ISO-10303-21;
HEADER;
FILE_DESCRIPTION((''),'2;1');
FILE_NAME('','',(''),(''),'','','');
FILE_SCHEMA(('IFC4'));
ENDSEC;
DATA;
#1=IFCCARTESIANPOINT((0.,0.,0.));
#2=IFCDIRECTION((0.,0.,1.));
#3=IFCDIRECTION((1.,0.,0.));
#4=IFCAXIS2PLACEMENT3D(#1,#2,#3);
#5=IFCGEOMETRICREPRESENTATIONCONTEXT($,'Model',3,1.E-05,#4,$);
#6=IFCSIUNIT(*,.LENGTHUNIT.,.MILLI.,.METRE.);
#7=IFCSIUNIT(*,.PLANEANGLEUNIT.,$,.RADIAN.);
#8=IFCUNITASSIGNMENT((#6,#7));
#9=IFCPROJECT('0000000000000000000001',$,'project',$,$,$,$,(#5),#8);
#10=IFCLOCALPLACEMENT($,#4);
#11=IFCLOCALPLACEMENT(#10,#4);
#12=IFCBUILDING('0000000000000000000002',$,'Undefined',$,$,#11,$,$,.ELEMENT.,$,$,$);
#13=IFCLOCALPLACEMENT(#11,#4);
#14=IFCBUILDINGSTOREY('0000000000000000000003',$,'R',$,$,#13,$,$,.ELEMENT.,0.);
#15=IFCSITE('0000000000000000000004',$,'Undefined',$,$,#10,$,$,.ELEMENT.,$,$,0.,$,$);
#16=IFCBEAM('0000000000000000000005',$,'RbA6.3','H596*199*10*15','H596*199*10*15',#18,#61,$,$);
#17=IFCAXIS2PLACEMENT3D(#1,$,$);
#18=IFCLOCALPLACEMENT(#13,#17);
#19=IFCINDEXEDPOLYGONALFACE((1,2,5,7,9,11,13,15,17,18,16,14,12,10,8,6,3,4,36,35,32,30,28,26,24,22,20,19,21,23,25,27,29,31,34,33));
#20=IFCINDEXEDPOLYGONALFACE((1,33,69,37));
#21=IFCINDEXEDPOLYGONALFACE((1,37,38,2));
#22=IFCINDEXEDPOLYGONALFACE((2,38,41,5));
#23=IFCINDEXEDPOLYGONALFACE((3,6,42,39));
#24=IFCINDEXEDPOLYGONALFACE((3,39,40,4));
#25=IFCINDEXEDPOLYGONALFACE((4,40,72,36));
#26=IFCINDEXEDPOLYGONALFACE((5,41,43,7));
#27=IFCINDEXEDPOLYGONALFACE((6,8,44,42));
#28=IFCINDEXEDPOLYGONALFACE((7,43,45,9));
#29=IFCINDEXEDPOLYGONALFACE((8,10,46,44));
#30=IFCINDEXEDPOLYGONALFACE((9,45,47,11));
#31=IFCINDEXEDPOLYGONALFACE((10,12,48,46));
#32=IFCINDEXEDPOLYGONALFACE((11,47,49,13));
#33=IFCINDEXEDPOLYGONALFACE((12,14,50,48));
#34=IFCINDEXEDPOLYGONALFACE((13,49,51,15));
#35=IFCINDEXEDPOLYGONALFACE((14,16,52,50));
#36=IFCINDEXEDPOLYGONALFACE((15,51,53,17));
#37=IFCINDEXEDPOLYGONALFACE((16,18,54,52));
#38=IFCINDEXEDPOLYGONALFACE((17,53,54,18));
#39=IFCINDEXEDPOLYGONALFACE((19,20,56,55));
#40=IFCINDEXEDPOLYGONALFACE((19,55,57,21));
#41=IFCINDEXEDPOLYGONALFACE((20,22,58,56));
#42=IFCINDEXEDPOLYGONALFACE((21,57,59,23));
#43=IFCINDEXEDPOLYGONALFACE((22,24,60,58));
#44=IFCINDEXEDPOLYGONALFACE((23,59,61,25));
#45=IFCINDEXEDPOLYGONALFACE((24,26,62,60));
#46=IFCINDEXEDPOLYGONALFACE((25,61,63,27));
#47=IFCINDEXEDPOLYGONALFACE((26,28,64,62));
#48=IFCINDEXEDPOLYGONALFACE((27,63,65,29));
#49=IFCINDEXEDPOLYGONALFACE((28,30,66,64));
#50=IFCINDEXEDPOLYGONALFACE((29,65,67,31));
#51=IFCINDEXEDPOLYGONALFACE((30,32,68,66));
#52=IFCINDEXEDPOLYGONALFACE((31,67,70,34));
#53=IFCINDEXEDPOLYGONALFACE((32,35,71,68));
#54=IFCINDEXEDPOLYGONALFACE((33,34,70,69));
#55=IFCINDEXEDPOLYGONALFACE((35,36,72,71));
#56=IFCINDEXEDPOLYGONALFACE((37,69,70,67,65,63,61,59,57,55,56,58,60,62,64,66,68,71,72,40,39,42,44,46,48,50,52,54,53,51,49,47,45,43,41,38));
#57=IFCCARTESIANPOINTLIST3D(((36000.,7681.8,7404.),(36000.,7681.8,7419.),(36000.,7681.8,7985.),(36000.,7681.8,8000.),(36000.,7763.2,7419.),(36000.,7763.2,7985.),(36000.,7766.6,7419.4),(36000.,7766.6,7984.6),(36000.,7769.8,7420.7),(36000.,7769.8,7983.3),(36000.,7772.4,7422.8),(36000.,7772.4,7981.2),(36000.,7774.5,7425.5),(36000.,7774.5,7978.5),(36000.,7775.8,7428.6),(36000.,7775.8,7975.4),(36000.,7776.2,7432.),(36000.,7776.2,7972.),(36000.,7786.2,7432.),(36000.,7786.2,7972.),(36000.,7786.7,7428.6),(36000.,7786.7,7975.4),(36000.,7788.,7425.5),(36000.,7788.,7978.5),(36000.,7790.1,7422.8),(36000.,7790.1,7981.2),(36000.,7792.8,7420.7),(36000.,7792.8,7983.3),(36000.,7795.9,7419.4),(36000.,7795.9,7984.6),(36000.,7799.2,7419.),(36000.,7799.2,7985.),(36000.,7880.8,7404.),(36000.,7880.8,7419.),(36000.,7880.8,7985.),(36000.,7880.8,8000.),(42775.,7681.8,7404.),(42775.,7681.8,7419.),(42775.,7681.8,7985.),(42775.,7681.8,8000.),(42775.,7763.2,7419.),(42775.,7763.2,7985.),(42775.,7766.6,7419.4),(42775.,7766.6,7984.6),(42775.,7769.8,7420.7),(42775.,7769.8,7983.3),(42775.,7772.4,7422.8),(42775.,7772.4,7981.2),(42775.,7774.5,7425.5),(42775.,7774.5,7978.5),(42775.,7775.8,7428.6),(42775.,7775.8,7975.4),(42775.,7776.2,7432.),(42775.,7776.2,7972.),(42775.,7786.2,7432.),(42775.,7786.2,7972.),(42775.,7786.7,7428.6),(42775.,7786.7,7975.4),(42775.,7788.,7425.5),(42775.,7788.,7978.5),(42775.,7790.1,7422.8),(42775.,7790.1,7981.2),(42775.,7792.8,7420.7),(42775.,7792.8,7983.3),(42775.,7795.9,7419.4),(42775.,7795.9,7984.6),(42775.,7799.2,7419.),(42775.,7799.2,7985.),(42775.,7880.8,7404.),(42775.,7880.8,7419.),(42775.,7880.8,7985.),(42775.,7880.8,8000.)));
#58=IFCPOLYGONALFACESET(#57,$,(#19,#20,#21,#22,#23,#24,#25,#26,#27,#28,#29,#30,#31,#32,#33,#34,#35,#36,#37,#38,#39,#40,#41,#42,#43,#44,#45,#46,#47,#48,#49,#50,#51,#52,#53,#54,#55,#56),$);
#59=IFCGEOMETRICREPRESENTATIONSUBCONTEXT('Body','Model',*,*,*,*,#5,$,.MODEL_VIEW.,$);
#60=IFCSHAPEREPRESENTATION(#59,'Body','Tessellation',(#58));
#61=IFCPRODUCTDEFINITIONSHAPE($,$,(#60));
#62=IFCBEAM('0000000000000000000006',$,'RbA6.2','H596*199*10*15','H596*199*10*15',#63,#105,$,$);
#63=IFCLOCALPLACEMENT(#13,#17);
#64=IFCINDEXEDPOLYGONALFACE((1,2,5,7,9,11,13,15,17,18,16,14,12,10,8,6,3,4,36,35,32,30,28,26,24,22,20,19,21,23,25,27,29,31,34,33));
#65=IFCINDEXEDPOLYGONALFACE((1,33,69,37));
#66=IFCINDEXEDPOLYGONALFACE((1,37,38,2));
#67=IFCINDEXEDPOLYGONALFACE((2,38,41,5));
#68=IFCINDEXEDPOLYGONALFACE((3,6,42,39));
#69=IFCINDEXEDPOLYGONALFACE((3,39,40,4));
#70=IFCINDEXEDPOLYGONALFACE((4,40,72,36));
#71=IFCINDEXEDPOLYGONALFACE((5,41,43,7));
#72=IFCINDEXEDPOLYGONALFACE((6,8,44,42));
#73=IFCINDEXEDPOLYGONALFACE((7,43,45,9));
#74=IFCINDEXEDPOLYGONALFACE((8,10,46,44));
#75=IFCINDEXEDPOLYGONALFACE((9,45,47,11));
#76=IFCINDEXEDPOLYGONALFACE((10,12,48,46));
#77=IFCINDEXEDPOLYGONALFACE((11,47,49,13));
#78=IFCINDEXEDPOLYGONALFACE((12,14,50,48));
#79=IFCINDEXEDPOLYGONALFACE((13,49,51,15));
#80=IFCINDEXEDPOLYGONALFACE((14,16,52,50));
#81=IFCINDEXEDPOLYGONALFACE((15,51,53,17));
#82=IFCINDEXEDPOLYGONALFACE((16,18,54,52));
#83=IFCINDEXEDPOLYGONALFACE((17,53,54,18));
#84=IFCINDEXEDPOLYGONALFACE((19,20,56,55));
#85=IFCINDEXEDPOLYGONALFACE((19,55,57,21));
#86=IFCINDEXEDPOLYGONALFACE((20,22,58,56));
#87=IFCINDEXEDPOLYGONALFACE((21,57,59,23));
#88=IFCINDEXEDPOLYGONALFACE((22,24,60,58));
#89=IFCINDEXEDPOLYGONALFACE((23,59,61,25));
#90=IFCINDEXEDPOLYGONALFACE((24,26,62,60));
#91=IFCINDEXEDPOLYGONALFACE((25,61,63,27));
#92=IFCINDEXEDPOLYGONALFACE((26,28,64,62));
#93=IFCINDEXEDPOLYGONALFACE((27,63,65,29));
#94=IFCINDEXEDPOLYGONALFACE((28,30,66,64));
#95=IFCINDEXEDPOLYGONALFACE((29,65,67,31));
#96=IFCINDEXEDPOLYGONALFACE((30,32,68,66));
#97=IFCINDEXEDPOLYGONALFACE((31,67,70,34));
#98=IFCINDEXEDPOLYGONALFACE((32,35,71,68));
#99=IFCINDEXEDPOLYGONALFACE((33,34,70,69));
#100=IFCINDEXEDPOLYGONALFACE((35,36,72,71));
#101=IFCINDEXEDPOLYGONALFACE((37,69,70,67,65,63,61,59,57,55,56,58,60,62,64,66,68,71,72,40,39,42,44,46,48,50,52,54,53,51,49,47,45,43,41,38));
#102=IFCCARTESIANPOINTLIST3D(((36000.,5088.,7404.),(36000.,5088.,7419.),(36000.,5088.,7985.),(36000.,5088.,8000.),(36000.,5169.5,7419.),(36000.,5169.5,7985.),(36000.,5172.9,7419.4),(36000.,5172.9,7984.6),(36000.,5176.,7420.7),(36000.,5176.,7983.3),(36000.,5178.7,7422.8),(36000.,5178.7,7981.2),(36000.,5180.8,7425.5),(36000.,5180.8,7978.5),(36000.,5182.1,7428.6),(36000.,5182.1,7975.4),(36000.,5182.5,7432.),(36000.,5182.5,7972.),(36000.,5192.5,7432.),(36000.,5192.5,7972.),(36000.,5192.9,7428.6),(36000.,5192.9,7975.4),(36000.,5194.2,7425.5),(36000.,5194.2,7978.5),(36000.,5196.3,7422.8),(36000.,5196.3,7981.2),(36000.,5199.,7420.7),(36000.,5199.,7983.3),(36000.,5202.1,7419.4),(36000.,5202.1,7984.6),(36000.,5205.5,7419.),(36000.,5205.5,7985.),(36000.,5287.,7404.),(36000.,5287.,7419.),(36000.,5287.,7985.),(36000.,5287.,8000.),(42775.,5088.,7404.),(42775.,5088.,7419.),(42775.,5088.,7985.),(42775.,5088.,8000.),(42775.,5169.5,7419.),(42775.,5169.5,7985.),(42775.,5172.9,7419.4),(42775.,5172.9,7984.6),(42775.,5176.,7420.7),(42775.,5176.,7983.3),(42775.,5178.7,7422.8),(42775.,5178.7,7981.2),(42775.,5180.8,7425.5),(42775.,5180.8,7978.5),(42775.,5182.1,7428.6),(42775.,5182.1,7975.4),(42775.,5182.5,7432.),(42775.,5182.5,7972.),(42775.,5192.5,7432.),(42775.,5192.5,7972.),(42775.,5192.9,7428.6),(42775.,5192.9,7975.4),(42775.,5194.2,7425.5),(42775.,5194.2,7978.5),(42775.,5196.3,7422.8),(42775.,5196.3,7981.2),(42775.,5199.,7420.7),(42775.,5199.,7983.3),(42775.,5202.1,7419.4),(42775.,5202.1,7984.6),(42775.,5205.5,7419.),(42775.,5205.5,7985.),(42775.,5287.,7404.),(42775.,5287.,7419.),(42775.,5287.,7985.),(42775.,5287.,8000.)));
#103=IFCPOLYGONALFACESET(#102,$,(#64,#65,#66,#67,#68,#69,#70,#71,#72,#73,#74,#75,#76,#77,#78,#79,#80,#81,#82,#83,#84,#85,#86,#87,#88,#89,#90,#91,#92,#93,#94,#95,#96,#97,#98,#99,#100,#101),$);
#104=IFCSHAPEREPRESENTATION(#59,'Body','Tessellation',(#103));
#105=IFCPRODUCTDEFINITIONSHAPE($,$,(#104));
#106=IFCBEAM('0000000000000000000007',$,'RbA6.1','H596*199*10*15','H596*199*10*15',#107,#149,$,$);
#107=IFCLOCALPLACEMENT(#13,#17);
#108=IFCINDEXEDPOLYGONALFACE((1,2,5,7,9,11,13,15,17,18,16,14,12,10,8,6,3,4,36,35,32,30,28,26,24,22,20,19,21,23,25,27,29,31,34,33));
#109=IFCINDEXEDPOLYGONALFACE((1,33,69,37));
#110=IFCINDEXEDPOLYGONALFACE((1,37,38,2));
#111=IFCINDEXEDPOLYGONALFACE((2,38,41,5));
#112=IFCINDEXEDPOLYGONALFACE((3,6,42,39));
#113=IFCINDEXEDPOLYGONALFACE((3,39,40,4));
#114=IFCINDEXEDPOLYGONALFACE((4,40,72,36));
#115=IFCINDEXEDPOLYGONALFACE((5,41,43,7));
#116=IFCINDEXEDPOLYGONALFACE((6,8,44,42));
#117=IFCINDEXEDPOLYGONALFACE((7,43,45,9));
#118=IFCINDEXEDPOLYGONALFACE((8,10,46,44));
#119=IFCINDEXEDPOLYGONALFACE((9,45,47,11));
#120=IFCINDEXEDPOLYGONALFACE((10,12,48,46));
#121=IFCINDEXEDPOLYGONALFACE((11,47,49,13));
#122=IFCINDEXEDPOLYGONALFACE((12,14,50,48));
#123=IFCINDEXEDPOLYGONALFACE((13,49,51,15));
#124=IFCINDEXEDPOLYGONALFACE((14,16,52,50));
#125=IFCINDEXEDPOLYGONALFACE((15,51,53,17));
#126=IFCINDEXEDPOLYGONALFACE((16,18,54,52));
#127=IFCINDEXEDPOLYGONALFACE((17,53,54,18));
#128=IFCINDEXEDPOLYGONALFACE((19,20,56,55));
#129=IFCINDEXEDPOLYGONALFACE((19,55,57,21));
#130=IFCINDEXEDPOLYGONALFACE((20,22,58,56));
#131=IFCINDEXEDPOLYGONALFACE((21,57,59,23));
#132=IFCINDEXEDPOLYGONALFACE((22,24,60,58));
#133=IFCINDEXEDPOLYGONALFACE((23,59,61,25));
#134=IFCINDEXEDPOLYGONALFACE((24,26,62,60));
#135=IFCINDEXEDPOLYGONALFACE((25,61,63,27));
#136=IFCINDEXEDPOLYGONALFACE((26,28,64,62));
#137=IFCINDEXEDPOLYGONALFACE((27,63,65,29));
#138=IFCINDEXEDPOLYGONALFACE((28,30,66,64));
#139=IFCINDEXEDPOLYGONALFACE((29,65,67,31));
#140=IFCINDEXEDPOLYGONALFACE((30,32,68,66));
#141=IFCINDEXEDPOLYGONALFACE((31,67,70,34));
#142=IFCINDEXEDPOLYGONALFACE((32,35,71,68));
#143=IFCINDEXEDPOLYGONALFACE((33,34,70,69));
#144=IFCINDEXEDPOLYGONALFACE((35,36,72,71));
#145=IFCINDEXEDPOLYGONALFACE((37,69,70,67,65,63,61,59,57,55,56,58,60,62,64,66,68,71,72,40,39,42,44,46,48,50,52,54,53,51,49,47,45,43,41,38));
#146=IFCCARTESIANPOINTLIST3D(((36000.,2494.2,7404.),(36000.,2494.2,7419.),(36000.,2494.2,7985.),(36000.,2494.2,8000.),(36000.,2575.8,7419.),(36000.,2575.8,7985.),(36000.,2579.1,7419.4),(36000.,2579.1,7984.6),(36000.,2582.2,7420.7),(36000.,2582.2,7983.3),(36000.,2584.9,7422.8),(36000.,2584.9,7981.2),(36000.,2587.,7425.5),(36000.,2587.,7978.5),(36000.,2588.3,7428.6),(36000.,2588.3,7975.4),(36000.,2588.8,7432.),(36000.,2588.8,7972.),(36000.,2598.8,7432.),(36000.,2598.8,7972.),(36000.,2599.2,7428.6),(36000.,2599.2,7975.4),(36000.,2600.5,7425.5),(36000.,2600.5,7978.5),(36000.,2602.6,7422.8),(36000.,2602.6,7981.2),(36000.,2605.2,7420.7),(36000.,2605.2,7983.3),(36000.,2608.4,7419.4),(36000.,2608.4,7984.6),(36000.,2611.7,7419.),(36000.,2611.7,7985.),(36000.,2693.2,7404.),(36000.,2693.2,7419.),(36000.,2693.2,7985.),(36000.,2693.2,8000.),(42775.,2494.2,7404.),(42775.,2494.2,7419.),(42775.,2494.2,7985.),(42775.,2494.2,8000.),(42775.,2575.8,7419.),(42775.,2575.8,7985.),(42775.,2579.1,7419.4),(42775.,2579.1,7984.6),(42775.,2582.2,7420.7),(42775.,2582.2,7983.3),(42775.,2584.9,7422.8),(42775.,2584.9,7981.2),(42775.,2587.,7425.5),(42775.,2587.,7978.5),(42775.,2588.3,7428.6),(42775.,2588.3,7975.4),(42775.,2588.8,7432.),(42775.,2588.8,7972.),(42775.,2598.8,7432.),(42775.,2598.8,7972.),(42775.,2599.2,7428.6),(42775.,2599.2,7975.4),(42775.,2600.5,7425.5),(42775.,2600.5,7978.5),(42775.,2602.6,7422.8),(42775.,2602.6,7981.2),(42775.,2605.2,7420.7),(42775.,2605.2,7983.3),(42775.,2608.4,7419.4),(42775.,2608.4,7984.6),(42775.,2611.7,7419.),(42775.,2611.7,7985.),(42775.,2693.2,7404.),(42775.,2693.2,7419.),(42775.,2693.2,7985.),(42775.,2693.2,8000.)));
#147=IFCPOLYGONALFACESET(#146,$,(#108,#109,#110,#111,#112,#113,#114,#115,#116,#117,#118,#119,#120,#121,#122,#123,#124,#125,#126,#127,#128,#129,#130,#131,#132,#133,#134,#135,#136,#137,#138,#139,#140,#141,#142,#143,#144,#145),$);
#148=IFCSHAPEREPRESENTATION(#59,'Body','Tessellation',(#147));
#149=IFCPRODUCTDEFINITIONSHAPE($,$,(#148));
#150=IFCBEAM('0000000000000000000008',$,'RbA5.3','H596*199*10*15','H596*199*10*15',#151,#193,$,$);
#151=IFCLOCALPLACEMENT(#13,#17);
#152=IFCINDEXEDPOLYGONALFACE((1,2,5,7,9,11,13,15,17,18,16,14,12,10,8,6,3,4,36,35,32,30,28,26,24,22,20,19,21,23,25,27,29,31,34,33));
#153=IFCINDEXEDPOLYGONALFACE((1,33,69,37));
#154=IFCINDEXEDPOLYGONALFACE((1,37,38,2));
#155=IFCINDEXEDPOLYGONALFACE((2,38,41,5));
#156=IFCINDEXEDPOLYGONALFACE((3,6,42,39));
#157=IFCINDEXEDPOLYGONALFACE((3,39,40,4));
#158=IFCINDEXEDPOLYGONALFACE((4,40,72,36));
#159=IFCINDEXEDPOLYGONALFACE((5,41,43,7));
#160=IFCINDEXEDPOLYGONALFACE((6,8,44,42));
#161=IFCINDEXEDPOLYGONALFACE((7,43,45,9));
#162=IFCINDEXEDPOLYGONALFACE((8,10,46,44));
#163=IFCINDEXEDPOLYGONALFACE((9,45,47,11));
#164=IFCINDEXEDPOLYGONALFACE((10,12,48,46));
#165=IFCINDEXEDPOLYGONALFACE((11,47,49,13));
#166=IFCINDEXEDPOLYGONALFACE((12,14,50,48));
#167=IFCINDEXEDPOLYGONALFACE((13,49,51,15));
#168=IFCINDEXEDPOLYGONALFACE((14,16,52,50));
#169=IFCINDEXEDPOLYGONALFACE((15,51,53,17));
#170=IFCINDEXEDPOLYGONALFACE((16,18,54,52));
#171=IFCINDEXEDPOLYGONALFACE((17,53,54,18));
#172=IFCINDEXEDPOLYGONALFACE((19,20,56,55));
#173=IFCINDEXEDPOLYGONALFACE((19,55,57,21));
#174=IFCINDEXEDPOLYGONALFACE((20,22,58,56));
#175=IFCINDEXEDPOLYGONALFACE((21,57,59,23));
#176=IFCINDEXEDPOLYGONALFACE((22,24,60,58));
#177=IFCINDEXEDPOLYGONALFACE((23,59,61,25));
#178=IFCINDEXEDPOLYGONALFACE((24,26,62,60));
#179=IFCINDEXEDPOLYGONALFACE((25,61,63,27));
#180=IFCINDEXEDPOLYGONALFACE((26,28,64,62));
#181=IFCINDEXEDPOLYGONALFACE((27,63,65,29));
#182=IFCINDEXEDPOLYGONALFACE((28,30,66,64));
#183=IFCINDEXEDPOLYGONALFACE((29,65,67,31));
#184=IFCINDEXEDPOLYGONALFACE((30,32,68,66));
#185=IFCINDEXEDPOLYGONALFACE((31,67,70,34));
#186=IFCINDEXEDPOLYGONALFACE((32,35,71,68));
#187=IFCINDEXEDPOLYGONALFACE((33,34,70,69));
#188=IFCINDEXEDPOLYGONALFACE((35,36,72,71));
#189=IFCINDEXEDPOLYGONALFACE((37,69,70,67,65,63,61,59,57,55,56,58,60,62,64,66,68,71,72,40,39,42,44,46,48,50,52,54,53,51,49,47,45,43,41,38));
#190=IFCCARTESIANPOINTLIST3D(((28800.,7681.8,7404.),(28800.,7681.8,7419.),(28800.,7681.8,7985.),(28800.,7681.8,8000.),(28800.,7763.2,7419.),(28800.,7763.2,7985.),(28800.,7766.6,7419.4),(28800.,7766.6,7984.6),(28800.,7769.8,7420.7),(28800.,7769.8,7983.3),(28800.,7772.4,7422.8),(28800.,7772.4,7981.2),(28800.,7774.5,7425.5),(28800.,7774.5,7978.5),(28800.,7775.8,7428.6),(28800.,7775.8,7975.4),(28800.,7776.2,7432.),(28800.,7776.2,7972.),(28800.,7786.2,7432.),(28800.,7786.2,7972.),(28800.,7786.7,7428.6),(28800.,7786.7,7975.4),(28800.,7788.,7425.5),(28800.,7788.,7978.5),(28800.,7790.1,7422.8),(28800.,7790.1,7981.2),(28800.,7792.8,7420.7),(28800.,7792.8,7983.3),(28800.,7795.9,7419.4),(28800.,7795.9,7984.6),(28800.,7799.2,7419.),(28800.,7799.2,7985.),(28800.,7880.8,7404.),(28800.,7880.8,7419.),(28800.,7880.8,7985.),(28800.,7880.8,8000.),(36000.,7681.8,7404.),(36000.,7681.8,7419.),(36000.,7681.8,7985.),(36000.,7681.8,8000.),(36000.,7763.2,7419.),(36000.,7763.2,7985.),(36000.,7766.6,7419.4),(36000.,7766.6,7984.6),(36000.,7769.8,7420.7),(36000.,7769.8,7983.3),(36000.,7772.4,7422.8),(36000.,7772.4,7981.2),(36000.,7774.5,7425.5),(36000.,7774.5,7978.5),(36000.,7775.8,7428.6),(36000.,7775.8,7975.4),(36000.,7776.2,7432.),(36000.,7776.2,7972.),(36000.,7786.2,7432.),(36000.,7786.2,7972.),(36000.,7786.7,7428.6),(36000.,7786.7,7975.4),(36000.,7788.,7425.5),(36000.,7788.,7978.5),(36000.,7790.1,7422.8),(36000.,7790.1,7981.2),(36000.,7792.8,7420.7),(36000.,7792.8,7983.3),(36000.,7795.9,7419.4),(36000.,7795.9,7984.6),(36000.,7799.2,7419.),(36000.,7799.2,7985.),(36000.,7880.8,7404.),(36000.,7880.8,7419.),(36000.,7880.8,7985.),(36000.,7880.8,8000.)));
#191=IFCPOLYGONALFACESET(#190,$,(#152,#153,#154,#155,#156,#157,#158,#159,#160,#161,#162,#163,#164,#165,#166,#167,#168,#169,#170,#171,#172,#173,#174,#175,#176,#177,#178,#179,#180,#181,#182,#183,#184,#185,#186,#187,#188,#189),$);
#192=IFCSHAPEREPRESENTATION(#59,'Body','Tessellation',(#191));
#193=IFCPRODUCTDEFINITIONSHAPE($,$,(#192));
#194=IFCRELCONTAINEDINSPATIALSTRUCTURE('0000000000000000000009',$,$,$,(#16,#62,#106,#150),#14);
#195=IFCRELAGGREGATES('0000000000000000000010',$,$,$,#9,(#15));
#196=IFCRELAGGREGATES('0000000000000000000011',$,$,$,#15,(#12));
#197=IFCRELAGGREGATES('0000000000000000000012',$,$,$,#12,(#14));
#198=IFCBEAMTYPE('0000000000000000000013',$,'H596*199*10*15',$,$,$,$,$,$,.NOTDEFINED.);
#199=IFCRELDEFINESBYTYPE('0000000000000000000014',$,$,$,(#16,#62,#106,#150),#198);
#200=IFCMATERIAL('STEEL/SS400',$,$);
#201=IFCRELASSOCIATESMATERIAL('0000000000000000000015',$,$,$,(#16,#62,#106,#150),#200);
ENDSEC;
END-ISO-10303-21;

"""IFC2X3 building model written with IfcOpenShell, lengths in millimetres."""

from ifc_helpers import new_model, si_unit, frame, origin_with_axes, origin_2d_with_axis, place, context, subcontext, project, spatial, i_section, extrude, material, type_object, element, save


model = new_model("IFC2X3")

# Units and contexts
model_context = context("Model", 3, precision=1e-05, world=origin_with_axes())
body_context = subcontext(model_context, "Body", "Model", "MODEL_VIEW")
ifc_project = project(units=[si_unit("LENGTHUNIT", "METRE", prefix="MILLI"), si_unit("PLANEANGLEUNIT", "RADIAN")], contexts=[model_context])

# Site, building, storey
site_placement = place(None, origin_with_axes())
site = spatial("IfcSite", under=ifc_project, at=site_placement, Name="Undefined", CompositionType="ELEMENT", RefElevation=0.0)
building_placement = place(site_placement, origin_with_axes())
building = spatial("IfcBuilding", under=site, at=building_placement, Name="Undefined", CompositionType="ELEMENT")
storey_placement = place(building_placement, origin_with_axes())
storey = spatial("IfcBuildingStorey", under=building, at=storey_placement, Name="R", CompositionType="ELEMENT", Elevation=0.0)

# Beams
ifc_material_1 = material(Name="STEEL/SS400")
beam_type_1 = type_object("IfcBeamType", Name="H596*199*10*15", PredefinedType="NOTDEFINED")
for number, where, z_axis, x_axis, name in (
    (1, (36000.0, 7781.2, 7702.0), (0.0, 0.0, 1.0), (1.0, 0.0, 0.0), "RbA6.3"),
    (2, (36000.0, 5187.5, 7702.0), (0.0, 0.0, 1.0), (1.0, 0.0, 0.0), "RbA6.2"),
    (3, (36000.0, 2593.8, 7702.0), (0.0, 0.0, 1.0), (1.0, 0.0, 0.0), "RbA6.1"),
):
    element("IfcBeam", number, at=place(storey_placement, frame(where, z_axis=z_axis, x_axis=x_axis)), inside=storey, type_object=beam_type_1, material=ifc_material_1, Name=name, Description="H596*199*10*15", ObjectType="H596*199*10*15", context=body_context, shape_type="SweptSolid", body=[
        extrude(i_section(OverallWidth=199.0, OverallDepth=596.0, WebThickness=10.0, FlangeThickness=15.0, FilletRadius=13.0, at=origin_2d_with_axis()), frame((6775.0, 0.0, 0.0), z_axis=(-1.0, 0.0, 0.0), x_axis=(0.0, -1.0, 0.0)), (0.0, 0.0, 1.0), 6775.0),
    ])
for number, where, z_axis, x_axis, name in (
    (4, (28800.0, 7781.2, 7702.0), (0.0, 0.0, 1.0), (1.0, 0.0, 0.0), "RbA5.3"),
):
    element("IfcBeam", number, at=place(storey_placement, frame(where, z_axis=z_axis, x_axis=x_axis)), inside=storey, type_object=beam_type_1, material=ifc_material_1, Name=name, Description="H596*199*10*15", ObjectType="H596*199*10*15", context=body_context, shape_type="SweptSolid", body=[
        extrude(i_section(OverallWidth=199.0, OverallDepth=596.0, WebThickness=10.0, FlangeThickness=15.0, FilletRadius=13.0, at=origin_2d_with_axis()), frame((7200.0, 0.0, 0.0), z_axis=(-1.0, 0.0, 0.0), x_axis=(0.0, -1.0, 0.0)), (0.0, 0.0, 1.0), 7200.0),
    ])

save(model, "model.ifc")
